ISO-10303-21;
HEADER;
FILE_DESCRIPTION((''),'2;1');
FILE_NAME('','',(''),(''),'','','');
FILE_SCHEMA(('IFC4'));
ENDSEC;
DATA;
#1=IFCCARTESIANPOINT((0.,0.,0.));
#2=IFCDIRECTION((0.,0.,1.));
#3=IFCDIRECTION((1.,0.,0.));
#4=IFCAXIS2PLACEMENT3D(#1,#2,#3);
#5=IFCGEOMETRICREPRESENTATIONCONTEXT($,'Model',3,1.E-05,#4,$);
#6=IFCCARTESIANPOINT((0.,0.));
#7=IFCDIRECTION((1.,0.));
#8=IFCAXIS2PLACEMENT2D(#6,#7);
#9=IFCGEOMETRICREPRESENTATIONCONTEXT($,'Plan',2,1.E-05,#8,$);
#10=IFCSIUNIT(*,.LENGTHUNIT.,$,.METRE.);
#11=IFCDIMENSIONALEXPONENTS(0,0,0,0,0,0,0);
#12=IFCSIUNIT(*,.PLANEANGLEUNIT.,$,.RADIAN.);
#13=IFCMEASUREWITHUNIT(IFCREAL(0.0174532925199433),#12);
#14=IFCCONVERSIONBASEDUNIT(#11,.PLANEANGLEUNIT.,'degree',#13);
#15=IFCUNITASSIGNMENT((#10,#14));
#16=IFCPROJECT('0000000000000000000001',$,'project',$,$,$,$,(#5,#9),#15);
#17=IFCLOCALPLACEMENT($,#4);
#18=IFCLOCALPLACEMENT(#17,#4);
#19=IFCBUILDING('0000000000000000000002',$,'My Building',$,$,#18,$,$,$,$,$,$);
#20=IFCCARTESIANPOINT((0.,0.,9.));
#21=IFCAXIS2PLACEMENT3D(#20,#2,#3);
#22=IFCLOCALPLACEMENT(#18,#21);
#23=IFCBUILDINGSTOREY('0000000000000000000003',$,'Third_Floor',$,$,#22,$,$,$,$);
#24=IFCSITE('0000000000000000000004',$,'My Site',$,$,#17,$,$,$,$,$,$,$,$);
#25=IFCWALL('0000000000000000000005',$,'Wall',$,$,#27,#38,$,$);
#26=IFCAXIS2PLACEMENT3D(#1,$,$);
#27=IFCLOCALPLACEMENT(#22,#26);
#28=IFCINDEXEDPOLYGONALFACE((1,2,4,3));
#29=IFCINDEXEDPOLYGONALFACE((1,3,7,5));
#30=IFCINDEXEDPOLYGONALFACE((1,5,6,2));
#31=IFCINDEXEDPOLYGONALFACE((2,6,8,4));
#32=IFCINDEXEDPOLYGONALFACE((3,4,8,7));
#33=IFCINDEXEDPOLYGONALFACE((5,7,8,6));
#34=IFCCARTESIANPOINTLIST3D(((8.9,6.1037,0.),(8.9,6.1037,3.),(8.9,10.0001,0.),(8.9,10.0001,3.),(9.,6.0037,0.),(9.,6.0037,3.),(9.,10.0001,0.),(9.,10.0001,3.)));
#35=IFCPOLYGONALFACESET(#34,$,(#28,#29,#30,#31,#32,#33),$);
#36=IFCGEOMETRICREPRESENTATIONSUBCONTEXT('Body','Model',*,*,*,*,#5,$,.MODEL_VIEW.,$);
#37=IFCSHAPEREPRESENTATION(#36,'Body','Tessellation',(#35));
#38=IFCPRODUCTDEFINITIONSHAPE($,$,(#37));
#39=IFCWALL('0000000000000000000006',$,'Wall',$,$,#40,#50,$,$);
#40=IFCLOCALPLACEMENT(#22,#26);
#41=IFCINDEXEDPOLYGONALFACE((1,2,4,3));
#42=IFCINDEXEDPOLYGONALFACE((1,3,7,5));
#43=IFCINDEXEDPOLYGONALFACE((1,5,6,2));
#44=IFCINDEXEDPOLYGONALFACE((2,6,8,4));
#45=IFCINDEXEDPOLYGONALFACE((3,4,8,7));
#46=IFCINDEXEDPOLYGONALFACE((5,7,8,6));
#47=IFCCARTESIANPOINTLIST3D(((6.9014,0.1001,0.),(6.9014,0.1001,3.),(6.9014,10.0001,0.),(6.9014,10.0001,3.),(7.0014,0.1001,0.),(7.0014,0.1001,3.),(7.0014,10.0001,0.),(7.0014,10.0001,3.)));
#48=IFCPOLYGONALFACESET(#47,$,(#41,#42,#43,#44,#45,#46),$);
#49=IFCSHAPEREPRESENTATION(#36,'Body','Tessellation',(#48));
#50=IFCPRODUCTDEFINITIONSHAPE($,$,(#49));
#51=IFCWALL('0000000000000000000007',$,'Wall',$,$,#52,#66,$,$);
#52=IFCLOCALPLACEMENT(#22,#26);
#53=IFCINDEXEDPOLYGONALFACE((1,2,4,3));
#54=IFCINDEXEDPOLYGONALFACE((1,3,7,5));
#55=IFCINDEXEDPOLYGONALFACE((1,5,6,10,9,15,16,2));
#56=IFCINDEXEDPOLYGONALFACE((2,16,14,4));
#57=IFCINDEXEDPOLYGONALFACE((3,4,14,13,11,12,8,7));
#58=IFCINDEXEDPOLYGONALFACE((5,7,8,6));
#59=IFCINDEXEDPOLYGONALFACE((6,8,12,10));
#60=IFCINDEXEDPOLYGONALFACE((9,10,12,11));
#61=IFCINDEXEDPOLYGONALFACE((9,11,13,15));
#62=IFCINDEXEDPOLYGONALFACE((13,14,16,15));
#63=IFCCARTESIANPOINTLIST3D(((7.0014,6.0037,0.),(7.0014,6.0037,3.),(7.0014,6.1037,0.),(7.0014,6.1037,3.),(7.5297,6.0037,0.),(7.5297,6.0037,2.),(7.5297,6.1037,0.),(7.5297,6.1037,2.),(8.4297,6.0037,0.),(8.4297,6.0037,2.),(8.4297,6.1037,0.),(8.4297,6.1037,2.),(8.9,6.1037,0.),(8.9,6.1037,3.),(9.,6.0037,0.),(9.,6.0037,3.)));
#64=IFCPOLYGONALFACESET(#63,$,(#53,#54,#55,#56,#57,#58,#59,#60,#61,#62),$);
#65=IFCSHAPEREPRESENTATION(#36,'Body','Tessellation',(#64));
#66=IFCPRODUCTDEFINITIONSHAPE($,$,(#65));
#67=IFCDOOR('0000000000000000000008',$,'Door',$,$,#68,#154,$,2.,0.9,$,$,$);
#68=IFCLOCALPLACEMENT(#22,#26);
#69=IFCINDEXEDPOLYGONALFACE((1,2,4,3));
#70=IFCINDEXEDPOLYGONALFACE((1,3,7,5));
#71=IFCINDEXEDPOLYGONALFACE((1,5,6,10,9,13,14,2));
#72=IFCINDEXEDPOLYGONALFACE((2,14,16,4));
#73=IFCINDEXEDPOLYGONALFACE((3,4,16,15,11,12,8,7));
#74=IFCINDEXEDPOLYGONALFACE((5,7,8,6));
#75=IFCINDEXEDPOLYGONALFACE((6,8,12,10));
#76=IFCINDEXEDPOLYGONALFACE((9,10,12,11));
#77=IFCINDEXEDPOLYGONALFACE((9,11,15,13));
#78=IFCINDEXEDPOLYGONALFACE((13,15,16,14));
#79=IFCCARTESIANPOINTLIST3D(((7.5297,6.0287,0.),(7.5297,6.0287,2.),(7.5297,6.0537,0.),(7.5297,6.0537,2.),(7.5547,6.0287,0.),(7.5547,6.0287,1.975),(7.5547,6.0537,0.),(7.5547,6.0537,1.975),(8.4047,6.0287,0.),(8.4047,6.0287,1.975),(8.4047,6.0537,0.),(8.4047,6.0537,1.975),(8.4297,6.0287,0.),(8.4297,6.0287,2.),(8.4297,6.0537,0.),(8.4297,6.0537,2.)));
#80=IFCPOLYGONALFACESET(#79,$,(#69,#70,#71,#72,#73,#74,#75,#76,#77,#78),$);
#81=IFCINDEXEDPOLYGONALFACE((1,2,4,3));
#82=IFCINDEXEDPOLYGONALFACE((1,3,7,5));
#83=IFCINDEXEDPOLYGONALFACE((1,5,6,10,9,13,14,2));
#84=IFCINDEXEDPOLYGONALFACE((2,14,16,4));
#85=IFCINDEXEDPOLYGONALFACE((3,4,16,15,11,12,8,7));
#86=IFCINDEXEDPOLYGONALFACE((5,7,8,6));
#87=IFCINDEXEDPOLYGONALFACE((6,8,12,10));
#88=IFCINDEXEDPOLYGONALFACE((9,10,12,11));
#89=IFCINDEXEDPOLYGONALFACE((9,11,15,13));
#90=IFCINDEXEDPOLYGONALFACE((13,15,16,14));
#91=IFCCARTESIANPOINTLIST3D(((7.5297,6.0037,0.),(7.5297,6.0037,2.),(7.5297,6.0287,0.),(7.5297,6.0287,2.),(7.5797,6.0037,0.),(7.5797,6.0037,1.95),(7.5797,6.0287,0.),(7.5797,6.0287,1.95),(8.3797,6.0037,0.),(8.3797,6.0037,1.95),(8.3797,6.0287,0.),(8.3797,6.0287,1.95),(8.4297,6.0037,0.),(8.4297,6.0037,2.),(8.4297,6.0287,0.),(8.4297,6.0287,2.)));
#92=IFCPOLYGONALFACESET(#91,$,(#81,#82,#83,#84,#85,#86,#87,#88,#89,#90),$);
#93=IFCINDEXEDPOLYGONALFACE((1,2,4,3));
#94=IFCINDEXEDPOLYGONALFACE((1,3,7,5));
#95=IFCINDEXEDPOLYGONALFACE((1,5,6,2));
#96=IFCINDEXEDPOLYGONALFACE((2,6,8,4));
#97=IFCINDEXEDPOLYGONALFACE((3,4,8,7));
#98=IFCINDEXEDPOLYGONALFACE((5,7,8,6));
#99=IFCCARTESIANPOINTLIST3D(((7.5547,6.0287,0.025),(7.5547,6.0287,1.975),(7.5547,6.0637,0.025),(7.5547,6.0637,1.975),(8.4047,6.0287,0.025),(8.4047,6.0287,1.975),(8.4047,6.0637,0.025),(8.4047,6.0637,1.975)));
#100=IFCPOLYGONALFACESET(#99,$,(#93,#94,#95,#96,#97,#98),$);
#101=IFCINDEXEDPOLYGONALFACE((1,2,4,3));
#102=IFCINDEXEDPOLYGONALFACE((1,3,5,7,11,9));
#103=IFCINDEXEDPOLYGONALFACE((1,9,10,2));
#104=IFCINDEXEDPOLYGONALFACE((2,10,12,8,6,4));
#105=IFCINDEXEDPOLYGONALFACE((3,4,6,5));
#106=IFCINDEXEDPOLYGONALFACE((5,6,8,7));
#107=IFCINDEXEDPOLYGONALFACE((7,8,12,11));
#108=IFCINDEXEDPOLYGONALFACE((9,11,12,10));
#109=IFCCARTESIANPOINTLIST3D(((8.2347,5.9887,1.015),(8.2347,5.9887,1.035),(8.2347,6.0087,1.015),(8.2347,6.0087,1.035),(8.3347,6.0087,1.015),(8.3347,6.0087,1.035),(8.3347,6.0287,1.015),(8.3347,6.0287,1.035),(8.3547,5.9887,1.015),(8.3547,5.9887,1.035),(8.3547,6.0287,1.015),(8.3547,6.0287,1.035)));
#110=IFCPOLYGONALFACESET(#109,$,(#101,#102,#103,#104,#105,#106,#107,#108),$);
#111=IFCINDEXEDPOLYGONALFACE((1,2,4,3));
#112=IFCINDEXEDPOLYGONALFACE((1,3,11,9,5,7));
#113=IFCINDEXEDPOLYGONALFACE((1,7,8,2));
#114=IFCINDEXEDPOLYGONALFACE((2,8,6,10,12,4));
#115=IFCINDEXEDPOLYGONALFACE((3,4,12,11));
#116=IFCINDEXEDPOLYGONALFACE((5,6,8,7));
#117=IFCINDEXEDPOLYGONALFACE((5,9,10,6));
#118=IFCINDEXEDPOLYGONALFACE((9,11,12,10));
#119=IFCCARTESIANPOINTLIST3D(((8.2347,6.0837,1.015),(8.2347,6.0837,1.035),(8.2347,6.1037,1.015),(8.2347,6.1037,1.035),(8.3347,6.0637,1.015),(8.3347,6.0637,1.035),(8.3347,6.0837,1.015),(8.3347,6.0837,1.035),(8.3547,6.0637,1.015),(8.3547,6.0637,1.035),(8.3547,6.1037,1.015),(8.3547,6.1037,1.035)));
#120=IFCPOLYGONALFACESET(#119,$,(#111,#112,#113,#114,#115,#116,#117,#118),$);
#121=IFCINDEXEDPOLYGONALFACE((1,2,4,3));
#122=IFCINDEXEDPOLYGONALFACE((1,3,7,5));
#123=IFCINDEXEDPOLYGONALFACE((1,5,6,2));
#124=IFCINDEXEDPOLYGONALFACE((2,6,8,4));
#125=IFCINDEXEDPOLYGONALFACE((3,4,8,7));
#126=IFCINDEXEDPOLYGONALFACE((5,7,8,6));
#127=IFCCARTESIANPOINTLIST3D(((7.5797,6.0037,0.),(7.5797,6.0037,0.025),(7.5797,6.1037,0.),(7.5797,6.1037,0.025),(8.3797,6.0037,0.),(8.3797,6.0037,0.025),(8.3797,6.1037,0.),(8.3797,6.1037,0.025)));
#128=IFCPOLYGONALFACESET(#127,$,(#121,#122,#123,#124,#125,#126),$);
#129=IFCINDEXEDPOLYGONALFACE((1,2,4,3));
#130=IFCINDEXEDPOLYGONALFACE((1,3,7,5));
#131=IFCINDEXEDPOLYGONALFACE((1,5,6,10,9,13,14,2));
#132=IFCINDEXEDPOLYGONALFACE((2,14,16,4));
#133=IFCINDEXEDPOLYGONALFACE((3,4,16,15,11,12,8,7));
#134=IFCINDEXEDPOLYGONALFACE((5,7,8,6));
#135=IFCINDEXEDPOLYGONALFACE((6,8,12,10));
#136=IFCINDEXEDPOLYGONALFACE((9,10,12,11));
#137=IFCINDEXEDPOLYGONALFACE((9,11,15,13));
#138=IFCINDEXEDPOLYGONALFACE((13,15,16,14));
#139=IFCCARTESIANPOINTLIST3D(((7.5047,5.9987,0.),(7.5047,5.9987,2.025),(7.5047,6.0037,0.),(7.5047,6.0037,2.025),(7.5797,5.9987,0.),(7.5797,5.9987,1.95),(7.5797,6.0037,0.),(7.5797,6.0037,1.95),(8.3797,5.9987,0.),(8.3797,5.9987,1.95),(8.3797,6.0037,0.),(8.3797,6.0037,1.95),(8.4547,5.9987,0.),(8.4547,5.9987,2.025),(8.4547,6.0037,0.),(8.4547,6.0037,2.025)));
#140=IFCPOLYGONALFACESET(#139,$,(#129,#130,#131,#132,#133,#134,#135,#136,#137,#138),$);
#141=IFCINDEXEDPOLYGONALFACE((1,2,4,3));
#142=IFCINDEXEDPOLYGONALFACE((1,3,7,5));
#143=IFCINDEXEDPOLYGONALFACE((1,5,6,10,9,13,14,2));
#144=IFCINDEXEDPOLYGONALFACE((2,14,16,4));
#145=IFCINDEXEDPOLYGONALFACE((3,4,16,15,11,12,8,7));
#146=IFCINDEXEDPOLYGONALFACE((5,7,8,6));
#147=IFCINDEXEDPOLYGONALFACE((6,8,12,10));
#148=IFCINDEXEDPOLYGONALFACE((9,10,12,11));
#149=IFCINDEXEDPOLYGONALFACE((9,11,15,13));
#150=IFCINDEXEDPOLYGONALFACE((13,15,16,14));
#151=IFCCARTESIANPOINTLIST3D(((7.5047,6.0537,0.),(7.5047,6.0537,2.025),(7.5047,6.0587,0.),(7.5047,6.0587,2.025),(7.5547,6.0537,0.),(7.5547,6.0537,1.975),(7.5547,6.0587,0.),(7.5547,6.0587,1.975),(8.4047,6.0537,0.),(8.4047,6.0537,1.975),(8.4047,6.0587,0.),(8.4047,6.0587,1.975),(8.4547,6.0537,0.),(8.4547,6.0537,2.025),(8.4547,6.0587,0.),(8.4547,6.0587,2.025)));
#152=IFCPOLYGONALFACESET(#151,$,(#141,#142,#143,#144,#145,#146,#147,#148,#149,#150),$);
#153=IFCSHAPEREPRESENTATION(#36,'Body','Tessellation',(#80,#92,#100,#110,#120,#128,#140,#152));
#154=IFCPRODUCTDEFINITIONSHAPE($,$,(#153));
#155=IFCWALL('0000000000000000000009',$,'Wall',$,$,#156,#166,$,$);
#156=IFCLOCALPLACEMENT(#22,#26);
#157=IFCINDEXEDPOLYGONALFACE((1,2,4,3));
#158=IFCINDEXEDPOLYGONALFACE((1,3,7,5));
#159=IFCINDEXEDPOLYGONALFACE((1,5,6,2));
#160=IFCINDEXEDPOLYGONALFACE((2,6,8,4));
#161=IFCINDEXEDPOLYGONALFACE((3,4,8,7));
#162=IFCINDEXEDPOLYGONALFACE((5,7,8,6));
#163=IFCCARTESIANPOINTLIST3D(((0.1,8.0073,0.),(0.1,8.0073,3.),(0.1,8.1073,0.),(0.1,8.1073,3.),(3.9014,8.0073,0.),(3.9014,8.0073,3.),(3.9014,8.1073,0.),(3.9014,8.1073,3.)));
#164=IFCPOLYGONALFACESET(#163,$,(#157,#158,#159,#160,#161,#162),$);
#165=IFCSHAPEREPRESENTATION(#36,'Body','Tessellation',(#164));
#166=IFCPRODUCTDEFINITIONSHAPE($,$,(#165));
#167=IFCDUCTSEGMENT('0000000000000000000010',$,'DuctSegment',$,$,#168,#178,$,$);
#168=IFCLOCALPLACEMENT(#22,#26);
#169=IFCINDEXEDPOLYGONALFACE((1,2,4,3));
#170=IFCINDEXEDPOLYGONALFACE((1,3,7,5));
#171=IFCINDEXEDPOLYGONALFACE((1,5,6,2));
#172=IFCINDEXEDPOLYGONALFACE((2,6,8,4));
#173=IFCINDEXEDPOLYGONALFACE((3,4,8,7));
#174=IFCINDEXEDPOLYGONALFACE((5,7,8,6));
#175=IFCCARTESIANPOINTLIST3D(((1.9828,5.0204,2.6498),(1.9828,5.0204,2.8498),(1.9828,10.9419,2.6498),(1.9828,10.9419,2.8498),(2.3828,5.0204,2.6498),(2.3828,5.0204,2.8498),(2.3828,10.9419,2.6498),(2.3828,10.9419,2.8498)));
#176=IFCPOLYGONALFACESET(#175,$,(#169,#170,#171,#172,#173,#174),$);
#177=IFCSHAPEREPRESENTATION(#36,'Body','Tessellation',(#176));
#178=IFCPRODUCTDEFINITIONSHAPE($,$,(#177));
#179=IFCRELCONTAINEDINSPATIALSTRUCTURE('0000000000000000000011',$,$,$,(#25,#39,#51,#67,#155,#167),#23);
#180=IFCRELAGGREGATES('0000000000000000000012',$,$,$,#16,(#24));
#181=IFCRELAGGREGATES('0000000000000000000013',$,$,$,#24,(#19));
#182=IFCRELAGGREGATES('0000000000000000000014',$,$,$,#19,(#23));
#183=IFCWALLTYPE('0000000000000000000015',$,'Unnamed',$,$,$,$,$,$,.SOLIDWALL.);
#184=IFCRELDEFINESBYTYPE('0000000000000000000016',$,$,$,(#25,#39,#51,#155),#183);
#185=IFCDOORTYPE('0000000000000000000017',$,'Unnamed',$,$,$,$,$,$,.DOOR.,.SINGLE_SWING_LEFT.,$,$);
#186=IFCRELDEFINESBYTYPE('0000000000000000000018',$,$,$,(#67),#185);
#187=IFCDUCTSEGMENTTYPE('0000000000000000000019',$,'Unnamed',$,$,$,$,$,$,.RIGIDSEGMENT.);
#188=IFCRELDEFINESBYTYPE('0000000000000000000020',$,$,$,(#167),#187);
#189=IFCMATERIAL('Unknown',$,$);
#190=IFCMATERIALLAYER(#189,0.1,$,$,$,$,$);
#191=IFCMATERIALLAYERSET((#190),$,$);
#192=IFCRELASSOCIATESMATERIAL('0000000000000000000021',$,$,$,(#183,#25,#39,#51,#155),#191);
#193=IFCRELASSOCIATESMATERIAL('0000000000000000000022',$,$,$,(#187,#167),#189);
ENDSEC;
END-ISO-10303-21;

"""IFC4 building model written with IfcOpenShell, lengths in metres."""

from ifc_helpers import new_model, entity, si_unit, converted_unit, frame, origin_with_axes, origin_2d_with_axis, place, context, subcontext, project, spatial, line, indexed_curve, rectangle, outline, extrude, shape, source, transform, mapped, material, layer, layer_set, layer_usage, material_profile, profile_set, profile_usage, type_object, type_shapes, element, fill, save


model = new_model("IFC4")

# Units and contexts
model_context = context("Model", 3, precision=1e-05, world=origin_with_axes())
plan_context = context("Plan", 2, precision=1e-05, world=origin_2d_with_axis())
body_context_1 = subcontext(model_context, "Body", "Model", "MODEL_VIEW")
body_context_2 = subcontext(plan_context, "Body", "Plan", "PLAN_VIEW")
ifc_project = project(units=[si_unit("LENGTHUNIT", "METRE"), converted_unit("PLANEANGLEUNIT", "degree", entity("IfcReal", 0.0174532925199433), si_unit("PLANEANGLEUNIT", "RADIAN"), dimensions=[0, 0, 0, 0, 0, 0, 0])], contexts=[model_context, plan_context])

# Site, building, storey
site_placement = place(None, origin_with_axes())
site = spatial("IfcSite", under=ifc_project, at=site_placement, Name="My Site")
building_placement = place(site_placement, origin_with_axes())
building = spatial("IfcBuilding", under=site, at=building_placement, Name="My Building")
storey_placement = place(building_placement, frame((0.0, 0.0, 9.0), z_axis=(0.0, 0.0, 1.0), x_axis=(1.0, 0.0, 0.0)))
storey = spatial("IfcBuildingStorey", under=building, at=storey_placement, Name="Third_Floor")

# Wall
ifc_material = material(Name="Unknown")
ifc_layer = layer(ifc_material, 0.1)
ifc_layer_set = layer_set([ifc_layer])
ifc_layer_usage_1 = layer_usage(ifc_layer_set, "AXIS2", "POSITIVE", 0.0)
wall_type = type_object("IfcWallType", Name="Unnamed", PredefinedType="SOLIDWALL", material=ifc_layer_set)
wall_1_placement = place(storey_placement, frame((9.0, 6.0037, 0.0), z_axis=(0.0, 0.0, 1.0), x_axis=(0.0, 1.0, 0.0)))
element("IfcWall", 1, at=wall_1_placement, inside=storey, type_object=wall_type, material=ifc_layer_usage_1, Name="Wall", context=body_context_1, shape_type="SweptSolid", body=[
    extrude(outline(indexed_curve([(0.0, 0.0), (0.1, 0.1), (3.9963, 0.1), (3.9963, 0.0)], segments=[line(1, 2, 3, 4, 1)])), origin_with_axes(), (0.0, 0.0, 1.0), 3.0),
])

# Shared definitions
shared_shape_1 = source(origin_with_axes(), body_context_1, "Body", "SweptSolid", [
    extrude(outline(indexed_curve([(0.0, 0.0), (0.9, 0.0), (0.9, 2.0), (0.0, 2.0)], segments=[line(1, 2, 3, 4, 1)])), frame((0.0, -0.6, 0.0), z_axis=(0.0, -1.0, 0.0), x_axis=(1.0, 0.0, 0.0)), (0.0, 0.0, -1.0), 1.2),
])
door_type = type_object("IfcDoorType", Name="Unnamed", OperationType="SINGLE_SWING_LEFT", PredefinedType="DOOR")
shared_shape_2 = source(origin_with_axes(), body_context_1, "Body", "SweptSolid", [
    extrude(outline(indexed_curve([(0.0, 0.0), (0.0, 2.0), (0.9, 2.0), (0.9, 0.0), (0.875, 0.0), (0.875, 1.975), (0.025, 1.975), (0.025, 0.0)], segments=[line(1, 2, 3, 4, 5, 6, 7, 8, 1)])), frame((0.0, 0.025, 0.0), z_axis=(0.0, -1.0, 0.0), x_axis=(1.0, 0.0, 0.0)), (0.0, 0.0, -1.0), 0.025),
    extrude(outline(indexed_curve([(0.0, 0.0), (0.0, 2.0), (0.9, 2.0), (0.9, 0.0), (0.85, 0.0), (0.85, 1.95), (0.05, 1.95), (0.05, 0.0)], segments=[line(1, 2, 3, 4, 5, 6, 7, 8, 1)])), frame((0.0, 0.0, 0.0), z_axis=(0.0, -1.0, 0.0), x_axis=(1.0, 0.0, 0.0)), (0.0, 0.0, -1.0), 0.025),
    extrude(outline(indexed_curve([(0.0, 0.0), (0.85, 0.0), (0.85, 0.035), (0.0, 0.035)], segments=[line(1, 2, 3, 4, 1)])), frame((0.025, 0.025, 0.025), z_axis=(0.0, 0.0, 1.0), x_axis=(1.0, 0.0, 0.0)), (0.0, 0.0, 1.0), 1.95),
    extrude(outline(indexed_curve([(0.0, 0.0), (0.0, -0.04), (-0.12, -0.04), (-0.12, -0.02), (-0.02, -0.02), (-0.02, 0.0)], segments=[line(1, 2, 3, 4, 5, 6, 1)])), frame((0.825, 0.025, 1.015), z_axis=(0.0, 0.0, 1.0), x_axis=(1.0, 0.0, 0.0)), (0.0, 0.0, 1.0), 0.02),
    extrude(outline(indexed_curve([(0.0, 0.0), (0.0, 0.04), (-0.12, 0.04), (-0.12, 0.02), (-0.02, 0.02), (-0.02, 0.0)], segments=[line(1, 2, 3, 4, 5, 6, 1)])), frame((0.825, 0.06, 1.015), z_axis=(0.0, 0.0, 1.0), x_axis=(1.0, 0.0, 0.0)), (0.0, 0.0, 1.0), 0.02),
    extrude(outline(indexed_curve([(0.0, 0.0), (0.8, 0.0), (0.8, 0.1), (0.0, 0.1)], segments=[line(1, 2, 3, 4, 1)])), frame((0.05, 0.0, 0.0), z_axis=(0.0, 0.0, 1.0), x_axis=(1.0, 0.0, 0.0)), (0.0, 0.0, 1.0), 0.025),
    extrude(outline(indexed_curve([(0.0, 0.0), (0.0, 2.025), (0.95, 2.025), (0.95, 0.0), (0.875, 0.0), (0.875, 1.95), (0.075, 1.95), (0.075, 0.0)], segments=[line(1, 2, 3, 4, 5, 6, 7, 8, 1)])), frame((-0.025, -0.005, 0.0), z_axis=(0.0, -1.0, 0.0), x_axis=(1.0, 0.0, 0.0)), (0.0, 0.0, -1.0), 0.005),
    extrude(outline(indexed_curve([(0.0, 0.0), (0.0, 2.025), (0.95, 2.025), (0.95, 0.0), (0.9, 0.0), (0.9, 1.975), (0.05, 1.975), (0.05, 0.0)], segments=[line(1, 2, 3, 4, 5, 6, 7, 8, 1)])), frame((-0.025, 0.05, 0.0), z_axis=(0.0, -1.0, 0.0), x_axis=(1.0, 0.0, 0.0)), (0.0, 0.0, -1.0), 0.005),
])
shared_shape_3 = source(origin_with_axes(), body_context_2, "Body", "Curve2D", [
    entity("IfcIndexedPolyCurve", entity("IfcCartesianPointList2D", [[0.0, 0.0], [0.0, 0.05], [0.025, 0.05], [0.025, 0.025], [0.05, 0.025], [0.05, 0.0]]), [entity("IfcLineIndex", [1, 2, 3, 4, 5, 6, 1])]),
    entity("IfcIndexedPolyCurve", entity("IfcCartesianPointList2D", [[0.9, 0.0], [0.9, 0.05], [0.875, 0.05], [0.875, 0.025], [0.85, 0.025], [0.85, 0.0]]), [entity("IfcLineIndex", [1, 2, 3, 4, 5, 6, 1])]),
    entity("IfcTrimmedCurve", entity("IfcEllipse", entity("IfcAxis2Placement2D", entity("IfcCartesianPoint", [0.06, 0.05]), entity("IfcDirection", [1.0, 0.0])), 0.815, 0.85), [entity("IfcCartesianPoint", [0.875, 0.05])], [entity("IfcCartesianPoint", [0.06, 0.9])], True, "CARTESIAN"),
    entity("IfcIndexedPolyCurve", entity("IfcCartesianPointList2D", [[0.025, 0.05], [0.06, 0.05], [0.06, 0.9], [0.025, 0.9]]), [entity("IfcLineIndex", [1, 2, 3, 4, 1])]),
])
type_shapes(door_type, [shared_shape_2, shared_shape_3])

# Wall
ifc_layer_usage_2 = layer_usage(ifc_layer_set, "AXIS2", "POSITIVE", 0.0)
wall_2_placement = place(storey_placement, frame((6.9014, 10.0001, 0.0), z_axis=(0.0, 0.0, 1.0), x_axis=(0.0, -1.0, 0.0)))
element("IfcWall", 2, at=wall_2_placement, inside=storey, type_object=wall_type, material=ifc_layer_usage_2, Name="Wall", context=body_context_1, shape_type="SweptSolid", body=[
    extrude(outline(indexed_curve([(0.0, 0.0), (0.0, 0.1), (9.9, 0.1), (9.9, 0.0)], segments=[line(1, 2, 3, 4, 1)])), origin_with_axes(), (0.0, 0.0, 1.0), 3.0),
])

# Wall, opening, door
ifc_layer_usage_3 = layer_usage(ifc_layer_set, "AXIS2", "POSITIVE", 0.0)
wall_3_placement = place(storey_placement, frame((7.0014, 6.0037, 0.0), z_axis=(0.0, 0.0, 1.0), x_axis=(1.0, 0.0, 0.0)))
wall_3 = element("IfcWall", 3, at=wall_3_placement, inside=storey, type_object=wall_type, material=ifc_layer_usage_3, Name="Wall", context=body_context_1, shape_type="SweptSolid", body=[
    extrude(outline(indexed_curve([(0.0, 0.0), (0.0, 0.1), (1.8986, 0.1), (1.9986, 0.0)], segments=[line(1, 2, 3, 4, 1)])), origin_with_axes(), (0.0, 0.0, 1.0), 3.0),
])
opening_1_placement = place(wall_3_placement, frame((0.5283, 0.0, 0.0), z_axis=(0.0, 0.0, 1.0), x_axis=(1.0, 0.0, 0.0)))
opening_1 = element("IfcOpeningElement", 4, at=opening_1_placement, cuts=wall_3, PredefinedType="OPENING", context=body_context_1, shape_type="MappedRepresentation", body=[
    mapped(shared_shape_1, transform((0.0, 0.0, 0.0), x_axis=(1.0, 0.0, 0.0), y_axis=(0.0, 1.0, 0.0), z_axis=(0.0, 0.0, 1.0), scale=1.0)),
])
door_1_placement = place(opening_1_placement, origin_with_axes())
door_1 = element("IfcDoor", 5, at=door_1_placement, inside=storey, type_object=door_type, Name="Door", OverallHeight=2.0, OverallWidth=0.9, shapes=[
    shape(body_context_1, "Body", "MappedRepresentation", [mapped(shared_shape_2, transform((0.0, 0.0, 0.0), x_axis=(1.0, 0.0, 0.0), y_axis=(0.0, 1.0, 0.0), z_axis=(0.0, 0.0, 1.0), scale=1.0))]),
    shape(body_context_2, "Body", "MappedRepresentation", [mapped(shared_shape_3, transform((0.0, 0.0, 0.0), x_axis=(1.0, 0.0, 0.0), y_axis=(0.0, 1.0, 0.0), z_axis=(0.0, 0.0, 1.0), scale=1.0))]),
])
fill(opening_1, door_1)

# Wall
ifc_layer_usage_4 = layer_usage(ifc_layer_set, "AXIS2", "POSITIVE", 0.0)
wall_4_placement = place(storey_placement, frame((0.1, 8.0073, 0.0), z_axis=(0.0, 0.0, 1.0), x_axis=(1.0, 0.0, 0.0)))
element("IfcWall", 6, at=wall_4_placement, inside=storey, type_object=wall_type, material=ifc_layer_usage_4, Name="Wall", context=body_context_1, shape_type="SweptSolid", body=[
    extrude(outline(indexed_curve([(0.0, 0.0), (0.0, 0.1), (3.8014, 0.1), (3.8014, 0.0)], segments=[line(1, 2, 3, 4, 1)])), origin_with_axes(), (0.0, 0.0, 1.0), 3.0),
])

# Duct segment
ifc_material_profile_1 = material_profile(ifc_material, rectangle(XDim=0.4, YDim=0.2))
ifc_profile_set_1 = profile_set([ifc_material_profile_1])
ifc_profile_usage_1 = profile_usage(ifc_profile_set_1, cardinal=5)
duct_segment_type = type_object("IfcDuctSegmentType", Name="Unnamed", PredefinedType="RIGIDSEGMENT", material=ifc_profile_set_1)
duct_segment_1_placement = place(storey_placement, frame((2.1828, 10.9419, 2.7498), z_axis=(0.0, -1.0, 0.0), x_axis=(1.0, 0.0, 0.0)))
element("IfcDuctSegment", 7, at=duct_segment_1_placement, inside=storey, type_object=duct_segment_type, material=ifc_profile_usage_1, Name="DuctSegment", context=body_context_1, shape_type="SweptSolid", body=[
    extrude(rectangle(XDim=0.4, YDim=0.2), origin_with_axes(), (0.0, 0.0, 1.0), 5.9215),
])

save(model, "model.ifc")
